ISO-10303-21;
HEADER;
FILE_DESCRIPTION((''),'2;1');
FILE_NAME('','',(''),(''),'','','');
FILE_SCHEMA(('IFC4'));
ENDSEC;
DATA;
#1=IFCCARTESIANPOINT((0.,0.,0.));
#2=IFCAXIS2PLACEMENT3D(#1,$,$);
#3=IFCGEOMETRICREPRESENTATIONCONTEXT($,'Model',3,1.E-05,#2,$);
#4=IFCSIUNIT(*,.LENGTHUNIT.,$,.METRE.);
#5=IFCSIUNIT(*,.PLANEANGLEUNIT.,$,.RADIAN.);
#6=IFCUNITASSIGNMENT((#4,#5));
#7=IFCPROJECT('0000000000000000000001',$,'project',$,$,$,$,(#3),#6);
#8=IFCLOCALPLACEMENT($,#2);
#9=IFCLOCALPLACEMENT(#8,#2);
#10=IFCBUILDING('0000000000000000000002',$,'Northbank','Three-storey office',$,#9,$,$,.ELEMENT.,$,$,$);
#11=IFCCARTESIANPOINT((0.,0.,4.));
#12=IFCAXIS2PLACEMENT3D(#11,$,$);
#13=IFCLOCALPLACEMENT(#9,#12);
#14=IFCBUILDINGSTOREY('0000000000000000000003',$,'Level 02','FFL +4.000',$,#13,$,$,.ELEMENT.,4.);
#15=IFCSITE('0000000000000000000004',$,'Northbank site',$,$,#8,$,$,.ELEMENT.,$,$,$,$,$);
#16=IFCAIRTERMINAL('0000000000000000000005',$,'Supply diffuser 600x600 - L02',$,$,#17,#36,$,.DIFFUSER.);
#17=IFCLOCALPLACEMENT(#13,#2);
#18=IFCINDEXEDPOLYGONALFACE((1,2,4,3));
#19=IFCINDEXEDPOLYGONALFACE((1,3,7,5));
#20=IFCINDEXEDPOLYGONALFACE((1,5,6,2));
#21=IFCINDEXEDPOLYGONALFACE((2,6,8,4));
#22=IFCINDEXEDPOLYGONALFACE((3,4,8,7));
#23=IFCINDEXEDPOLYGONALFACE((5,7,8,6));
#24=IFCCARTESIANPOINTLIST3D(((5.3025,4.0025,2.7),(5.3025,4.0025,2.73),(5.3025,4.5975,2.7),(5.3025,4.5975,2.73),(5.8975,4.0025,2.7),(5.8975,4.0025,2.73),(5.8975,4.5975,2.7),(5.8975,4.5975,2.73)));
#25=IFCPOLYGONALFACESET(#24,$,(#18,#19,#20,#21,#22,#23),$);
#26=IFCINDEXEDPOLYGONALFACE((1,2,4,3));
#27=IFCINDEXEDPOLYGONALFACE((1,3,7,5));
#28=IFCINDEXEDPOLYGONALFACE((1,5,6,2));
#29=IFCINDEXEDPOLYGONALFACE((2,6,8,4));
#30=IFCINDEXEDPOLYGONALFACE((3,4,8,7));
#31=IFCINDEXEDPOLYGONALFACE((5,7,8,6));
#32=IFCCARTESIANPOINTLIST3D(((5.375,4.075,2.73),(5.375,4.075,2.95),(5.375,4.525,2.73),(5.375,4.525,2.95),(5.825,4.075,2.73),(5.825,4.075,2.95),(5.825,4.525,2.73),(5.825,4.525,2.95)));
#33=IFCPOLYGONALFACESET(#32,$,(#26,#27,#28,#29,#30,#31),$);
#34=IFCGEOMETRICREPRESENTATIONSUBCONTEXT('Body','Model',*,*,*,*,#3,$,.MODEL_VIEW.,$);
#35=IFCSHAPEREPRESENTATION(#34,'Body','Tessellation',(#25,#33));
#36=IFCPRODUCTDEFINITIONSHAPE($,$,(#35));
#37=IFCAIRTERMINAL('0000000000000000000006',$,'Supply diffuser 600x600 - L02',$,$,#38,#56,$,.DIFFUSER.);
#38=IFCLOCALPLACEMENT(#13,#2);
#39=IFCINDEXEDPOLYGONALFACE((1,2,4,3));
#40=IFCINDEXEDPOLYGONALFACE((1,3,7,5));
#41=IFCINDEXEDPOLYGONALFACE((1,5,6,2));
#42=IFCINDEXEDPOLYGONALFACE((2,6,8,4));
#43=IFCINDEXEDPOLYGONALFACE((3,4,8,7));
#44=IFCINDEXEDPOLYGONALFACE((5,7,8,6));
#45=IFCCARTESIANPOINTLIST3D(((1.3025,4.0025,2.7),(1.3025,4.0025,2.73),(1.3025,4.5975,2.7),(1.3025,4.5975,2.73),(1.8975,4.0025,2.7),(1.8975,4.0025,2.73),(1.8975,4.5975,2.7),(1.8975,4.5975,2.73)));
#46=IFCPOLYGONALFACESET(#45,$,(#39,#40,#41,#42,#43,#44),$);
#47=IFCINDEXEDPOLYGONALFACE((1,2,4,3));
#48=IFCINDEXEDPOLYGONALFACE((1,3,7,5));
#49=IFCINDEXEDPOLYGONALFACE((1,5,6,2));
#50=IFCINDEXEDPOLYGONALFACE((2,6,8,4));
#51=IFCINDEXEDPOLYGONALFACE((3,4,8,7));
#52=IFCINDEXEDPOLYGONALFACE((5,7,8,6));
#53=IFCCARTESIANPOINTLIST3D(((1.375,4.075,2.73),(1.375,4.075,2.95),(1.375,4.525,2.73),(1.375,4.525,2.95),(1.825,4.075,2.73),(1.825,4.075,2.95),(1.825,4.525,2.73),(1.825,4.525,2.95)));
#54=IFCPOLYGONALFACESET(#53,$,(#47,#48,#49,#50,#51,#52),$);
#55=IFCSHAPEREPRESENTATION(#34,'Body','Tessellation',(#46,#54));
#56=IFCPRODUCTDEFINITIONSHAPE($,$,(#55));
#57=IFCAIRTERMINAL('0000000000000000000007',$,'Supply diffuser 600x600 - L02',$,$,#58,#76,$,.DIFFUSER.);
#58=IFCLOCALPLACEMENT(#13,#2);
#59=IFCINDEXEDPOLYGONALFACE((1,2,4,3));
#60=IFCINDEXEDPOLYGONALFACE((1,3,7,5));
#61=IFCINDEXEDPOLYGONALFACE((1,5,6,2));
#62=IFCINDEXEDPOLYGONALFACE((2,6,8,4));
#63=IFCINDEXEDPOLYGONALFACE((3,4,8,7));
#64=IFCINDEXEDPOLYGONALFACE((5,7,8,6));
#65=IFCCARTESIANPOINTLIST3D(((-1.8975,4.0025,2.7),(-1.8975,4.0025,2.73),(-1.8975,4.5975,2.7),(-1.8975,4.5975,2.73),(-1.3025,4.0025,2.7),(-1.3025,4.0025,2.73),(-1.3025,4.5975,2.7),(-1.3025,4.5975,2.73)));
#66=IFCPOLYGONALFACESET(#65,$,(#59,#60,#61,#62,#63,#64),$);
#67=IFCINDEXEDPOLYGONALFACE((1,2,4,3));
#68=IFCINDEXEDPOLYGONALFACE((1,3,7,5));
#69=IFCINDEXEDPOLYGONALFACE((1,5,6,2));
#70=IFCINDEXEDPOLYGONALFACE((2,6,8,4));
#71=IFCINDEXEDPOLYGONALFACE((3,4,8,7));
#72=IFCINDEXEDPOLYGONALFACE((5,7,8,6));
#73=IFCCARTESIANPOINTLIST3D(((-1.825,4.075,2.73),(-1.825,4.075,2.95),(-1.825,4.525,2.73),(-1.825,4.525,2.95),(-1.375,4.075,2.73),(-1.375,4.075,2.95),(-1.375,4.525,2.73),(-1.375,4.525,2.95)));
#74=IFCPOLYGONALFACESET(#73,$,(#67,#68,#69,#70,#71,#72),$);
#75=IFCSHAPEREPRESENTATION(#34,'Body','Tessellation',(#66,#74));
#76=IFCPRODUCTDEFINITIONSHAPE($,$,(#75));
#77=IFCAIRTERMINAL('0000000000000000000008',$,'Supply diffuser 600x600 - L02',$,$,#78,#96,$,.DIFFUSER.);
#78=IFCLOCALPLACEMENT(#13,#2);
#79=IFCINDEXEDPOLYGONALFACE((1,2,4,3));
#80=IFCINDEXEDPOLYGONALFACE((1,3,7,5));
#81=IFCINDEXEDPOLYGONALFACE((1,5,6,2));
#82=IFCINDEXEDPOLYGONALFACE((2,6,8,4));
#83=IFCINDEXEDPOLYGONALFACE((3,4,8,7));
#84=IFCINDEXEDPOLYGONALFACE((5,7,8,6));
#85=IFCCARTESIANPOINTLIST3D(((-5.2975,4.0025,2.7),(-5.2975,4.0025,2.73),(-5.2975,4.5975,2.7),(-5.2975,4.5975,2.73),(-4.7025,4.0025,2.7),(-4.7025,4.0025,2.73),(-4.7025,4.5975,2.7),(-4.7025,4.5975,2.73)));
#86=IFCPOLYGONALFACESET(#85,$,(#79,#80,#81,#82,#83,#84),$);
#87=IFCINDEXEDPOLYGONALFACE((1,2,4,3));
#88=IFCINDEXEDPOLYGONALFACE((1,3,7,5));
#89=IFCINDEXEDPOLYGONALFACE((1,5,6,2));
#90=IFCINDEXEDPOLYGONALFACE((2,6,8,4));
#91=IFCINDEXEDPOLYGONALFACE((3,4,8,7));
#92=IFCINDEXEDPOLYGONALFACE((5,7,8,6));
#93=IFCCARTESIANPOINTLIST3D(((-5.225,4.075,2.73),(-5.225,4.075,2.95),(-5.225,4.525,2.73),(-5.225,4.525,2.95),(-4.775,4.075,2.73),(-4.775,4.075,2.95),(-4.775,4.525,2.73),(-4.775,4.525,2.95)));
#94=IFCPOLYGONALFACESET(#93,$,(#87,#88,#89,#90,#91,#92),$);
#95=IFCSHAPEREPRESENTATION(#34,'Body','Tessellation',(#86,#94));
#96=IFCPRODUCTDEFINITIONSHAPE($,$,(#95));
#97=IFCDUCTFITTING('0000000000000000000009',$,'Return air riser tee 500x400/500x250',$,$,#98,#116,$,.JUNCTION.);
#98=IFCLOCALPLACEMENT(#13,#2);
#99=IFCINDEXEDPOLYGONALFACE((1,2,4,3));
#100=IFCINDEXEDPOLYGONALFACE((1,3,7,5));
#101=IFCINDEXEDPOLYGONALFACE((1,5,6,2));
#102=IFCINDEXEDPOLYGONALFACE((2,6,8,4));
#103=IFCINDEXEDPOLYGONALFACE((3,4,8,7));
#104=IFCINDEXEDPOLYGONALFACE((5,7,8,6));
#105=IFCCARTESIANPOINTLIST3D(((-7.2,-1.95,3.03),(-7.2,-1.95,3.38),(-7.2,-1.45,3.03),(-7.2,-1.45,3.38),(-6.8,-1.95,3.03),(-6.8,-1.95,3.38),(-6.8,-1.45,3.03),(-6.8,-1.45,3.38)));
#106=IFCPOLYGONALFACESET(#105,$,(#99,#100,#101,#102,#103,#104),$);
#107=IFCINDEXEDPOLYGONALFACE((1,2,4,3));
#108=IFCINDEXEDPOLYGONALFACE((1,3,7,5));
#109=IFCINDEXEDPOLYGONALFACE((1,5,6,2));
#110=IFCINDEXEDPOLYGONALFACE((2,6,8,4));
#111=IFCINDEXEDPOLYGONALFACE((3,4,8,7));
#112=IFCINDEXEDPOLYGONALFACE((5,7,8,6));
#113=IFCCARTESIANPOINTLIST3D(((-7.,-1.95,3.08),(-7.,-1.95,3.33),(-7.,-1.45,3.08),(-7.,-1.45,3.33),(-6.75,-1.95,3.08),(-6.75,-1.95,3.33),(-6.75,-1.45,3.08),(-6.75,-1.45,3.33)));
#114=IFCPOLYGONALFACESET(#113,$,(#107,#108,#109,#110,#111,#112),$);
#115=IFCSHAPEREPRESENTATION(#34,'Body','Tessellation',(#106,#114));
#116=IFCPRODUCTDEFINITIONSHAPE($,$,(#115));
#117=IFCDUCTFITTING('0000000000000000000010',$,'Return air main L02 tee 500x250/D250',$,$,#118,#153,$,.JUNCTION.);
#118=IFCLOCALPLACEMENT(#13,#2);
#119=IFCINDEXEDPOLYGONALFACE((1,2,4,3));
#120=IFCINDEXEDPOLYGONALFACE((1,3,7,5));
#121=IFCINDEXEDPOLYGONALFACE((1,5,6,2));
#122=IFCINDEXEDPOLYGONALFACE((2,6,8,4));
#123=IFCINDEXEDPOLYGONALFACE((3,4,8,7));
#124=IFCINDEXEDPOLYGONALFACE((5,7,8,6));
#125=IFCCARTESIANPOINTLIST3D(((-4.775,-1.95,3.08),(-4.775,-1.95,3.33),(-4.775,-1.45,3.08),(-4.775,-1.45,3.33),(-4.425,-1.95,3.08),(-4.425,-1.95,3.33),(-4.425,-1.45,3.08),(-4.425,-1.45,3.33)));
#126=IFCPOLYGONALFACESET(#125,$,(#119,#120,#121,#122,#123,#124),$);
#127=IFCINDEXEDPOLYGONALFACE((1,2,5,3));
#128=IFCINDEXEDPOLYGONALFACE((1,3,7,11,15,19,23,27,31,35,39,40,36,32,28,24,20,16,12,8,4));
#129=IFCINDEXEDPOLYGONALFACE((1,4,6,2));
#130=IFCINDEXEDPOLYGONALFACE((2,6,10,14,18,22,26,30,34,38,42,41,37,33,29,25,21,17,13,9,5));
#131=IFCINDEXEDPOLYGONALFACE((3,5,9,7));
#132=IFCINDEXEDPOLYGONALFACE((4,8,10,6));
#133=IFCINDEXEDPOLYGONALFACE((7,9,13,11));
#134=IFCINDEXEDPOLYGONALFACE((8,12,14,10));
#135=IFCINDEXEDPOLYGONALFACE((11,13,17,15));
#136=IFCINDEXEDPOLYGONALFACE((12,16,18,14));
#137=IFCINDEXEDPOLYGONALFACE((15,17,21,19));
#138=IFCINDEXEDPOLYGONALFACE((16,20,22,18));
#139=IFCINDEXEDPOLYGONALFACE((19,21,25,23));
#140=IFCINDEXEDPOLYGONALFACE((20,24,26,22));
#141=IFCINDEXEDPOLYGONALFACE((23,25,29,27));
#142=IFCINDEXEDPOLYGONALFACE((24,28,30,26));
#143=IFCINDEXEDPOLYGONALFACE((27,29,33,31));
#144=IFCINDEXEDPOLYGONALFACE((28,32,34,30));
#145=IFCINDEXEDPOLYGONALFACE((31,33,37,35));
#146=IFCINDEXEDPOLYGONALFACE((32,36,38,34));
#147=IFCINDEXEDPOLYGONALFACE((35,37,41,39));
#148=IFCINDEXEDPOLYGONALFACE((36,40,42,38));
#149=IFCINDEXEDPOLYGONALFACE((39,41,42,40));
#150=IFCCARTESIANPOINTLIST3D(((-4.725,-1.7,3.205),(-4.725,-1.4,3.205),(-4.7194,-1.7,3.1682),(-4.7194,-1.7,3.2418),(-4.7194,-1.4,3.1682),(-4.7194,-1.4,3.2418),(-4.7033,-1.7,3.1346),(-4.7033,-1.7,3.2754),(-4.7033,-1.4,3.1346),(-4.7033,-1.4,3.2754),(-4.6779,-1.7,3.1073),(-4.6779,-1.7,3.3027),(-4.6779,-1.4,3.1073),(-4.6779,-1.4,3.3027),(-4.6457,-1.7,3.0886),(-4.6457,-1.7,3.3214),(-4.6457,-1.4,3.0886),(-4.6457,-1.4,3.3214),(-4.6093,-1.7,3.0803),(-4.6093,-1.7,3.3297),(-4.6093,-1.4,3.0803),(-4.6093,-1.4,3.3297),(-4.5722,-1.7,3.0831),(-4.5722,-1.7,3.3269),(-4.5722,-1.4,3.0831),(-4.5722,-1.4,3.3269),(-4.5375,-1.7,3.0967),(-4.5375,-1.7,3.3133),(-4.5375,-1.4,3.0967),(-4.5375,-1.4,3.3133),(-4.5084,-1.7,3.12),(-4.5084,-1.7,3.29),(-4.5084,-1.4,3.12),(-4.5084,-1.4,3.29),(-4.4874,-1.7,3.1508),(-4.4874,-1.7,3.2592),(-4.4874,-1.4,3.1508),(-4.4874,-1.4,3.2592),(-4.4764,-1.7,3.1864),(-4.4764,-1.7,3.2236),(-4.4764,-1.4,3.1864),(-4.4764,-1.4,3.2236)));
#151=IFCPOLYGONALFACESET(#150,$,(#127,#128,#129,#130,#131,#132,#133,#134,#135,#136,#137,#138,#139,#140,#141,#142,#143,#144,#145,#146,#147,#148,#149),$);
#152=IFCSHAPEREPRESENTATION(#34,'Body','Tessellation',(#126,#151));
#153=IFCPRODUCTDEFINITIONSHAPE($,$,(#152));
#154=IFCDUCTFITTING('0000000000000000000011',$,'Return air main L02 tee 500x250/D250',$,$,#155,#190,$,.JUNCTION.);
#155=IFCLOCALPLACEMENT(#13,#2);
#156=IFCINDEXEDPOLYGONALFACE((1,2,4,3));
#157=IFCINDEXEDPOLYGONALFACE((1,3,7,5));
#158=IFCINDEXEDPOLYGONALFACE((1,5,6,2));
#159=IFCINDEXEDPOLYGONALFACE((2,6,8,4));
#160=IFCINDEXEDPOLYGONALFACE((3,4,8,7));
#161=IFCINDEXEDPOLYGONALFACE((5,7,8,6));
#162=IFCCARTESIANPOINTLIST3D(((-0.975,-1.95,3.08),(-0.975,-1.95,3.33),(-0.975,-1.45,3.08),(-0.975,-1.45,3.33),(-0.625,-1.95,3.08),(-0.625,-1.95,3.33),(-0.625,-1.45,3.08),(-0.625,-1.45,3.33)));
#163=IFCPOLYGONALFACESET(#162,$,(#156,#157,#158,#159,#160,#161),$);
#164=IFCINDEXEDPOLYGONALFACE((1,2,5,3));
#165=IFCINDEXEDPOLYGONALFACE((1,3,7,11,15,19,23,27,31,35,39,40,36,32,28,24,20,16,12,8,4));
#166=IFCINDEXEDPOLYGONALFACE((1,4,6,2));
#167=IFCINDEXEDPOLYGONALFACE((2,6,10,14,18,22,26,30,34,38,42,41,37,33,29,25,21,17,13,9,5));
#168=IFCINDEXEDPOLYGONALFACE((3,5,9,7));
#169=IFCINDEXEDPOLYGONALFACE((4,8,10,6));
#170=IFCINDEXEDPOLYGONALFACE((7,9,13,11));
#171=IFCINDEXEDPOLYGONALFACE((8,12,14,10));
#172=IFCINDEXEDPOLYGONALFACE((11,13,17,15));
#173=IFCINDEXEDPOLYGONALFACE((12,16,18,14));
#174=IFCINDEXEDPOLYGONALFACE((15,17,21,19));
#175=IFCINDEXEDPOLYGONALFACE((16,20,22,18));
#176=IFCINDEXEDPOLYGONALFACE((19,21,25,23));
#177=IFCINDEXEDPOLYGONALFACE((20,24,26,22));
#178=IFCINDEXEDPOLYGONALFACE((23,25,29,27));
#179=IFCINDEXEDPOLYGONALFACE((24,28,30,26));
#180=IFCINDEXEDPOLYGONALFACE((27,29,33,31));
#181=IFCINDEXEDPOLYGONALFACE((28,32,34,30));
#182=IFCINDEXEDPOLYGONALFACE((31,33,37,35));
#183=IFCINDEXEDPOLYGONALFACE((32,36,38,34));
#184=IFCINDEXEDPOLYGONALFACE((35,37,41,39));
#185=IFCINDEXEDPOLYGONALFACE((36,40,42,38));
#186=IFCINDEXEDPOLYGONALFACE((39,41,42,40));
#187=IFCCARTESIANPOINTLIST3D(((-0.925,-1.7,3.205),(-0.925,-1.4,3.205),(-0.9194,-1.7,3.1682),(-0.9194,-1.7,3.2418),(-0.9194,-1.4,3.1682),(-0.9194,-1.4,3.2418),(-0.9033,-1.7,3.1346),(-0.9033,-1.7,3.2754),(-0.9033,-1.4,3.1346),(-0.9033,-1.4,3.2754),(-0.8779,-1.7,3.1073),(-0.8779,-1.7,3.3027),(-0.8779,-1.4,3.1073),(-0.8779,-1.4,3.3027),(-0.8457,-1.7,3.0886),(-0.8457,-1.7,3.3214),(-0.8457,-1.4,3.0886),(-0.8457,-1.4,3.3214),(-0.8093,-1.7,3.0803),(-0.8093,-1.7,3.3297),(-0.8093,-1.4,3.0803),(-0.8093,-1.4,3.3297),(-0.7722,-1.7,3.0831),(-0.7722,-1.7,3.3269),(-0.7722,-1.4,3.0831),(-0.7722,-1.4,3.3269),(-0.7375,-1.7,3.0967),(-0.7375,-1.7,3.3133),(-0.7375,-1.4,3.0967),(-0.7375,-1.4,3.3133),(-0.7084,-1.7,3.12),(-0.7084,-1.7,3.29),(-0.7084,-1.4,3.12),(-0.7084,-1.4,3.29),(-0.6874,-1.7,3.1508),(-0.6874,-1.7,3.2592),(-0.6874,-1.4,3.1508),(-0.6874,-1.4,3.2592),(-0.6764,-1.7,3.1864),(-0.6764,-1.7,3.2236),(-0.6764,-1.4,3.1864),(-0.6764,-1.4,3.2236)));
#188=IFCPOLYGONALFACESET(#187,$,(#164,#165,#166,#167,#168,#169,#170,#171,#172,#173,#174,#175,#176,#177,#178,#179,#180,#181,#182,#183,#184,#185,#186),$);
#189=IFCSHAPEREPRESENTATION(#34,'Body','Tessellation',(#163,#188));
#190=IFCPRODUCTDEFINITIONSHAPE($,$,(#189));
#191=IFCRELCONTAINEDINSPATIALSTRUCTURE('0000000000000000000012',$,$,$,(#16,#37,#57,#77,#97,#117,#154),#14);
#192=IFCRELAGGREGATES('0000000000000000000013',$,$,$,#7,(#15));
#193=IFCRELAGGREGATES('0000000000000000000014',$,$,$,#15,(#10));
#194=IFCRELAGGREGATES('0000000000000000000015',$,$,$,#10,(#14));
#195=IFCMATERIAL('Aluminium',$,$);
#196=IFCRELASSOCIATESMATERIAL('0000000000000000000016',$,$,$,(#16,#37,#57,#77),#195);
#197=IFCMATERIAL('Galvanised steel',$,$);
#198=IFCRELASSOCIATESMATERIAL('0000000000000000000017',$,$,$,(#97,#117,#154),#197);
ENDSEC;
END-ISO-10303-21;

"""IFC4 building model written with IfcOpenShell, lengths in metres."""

from ifc_helpers import new_model, si_unit, frame, origin, place, context, subcontext, project, spatial, rectangle, circle, extrude, material, element, save


model = new_model("IFC4")

# Units and contexts
model_context = context("Model", 3, precision=1e-05, world=origin())
body_context = subcontext(model_context, "Body", "Model", "MODEL_VIEW")
ifc_project = project(units=[si_unit("LENGTHUNIT", "METRE"), si_unit("PLANEANGLEUNIT", "RADIAN")], contexts=[model_context])

# Site, building, storey
site_placement = place(None, origin())
site = spatial("IfcSite", under=ifc_project, at=site_placement, Name="Northbank site", CompositionType="ELEMENT")
building_placement = place(site_placement, origin())
building = spatial("IfcBuilding", under=site, at=building_placement, Name="Northbank", Description="Three-storey office", CompositionType="ELEMENT")
storey_placement = place(building_placement, frame((0.0, 0.0, 4.0)))
storey = spatial("IfcBuildingStorey", under=building, at=storey_placement, Name="Level 02", Description="FFL +4.000", CompositionType="ELEMENT", Elevation=4.0)

# Air terminal
ifc_material_1 = material(Name="Aluminium")
air_terminal_1_placement = place(storey_placement, frame((0.0, 0.0, -4.0)))
element("IfcAirTerminal", 1, at=air_terminal_1_placement, inside=storey, material=ifc_material_1, Name="Supply diffuser 600x600 - L02", PredefinedType="DIFFUSER", context=body_context, shape_type="SweptSolid", body=[
    extrude(rectangle(XDim=0.595, YDim=0.595), frame((5.6, 4.3, 6.7)), (0.0, 0.0, 1.0), 0.03),
    extrude(rectangle(XDim=0.45, YDim=0.45), frame((5.6, 4.3, 6.73)), (0.0, 0.0, 1.0), 0.22),
])

# Shared definitions
ifc_material_2 = material(Name="Galvanised steel")

# Air terminal
air_terminal_2_placement = place(storey_placement, frame((0.0, 0.0, -4.0)))
element("IfcAirTerminal", 2, at=air_terminal_2_placement, inside=storey, material=ifc_material_1, Name="Supply diffuser 600x600 - L02", PredefinedType="DIFFUSER", context=body_context, shape_type="SweptSolid", body=[
    extrude(rectangle(XDim=0.595, YDim=0.595), frame((1.6, 4.3, 6.7)), (0.0, 0.0, 1.0), 0.03),
    extrude(rectangle(XDim=0.45, YDim=0.45), frame((1.6, 4.3, 6.73)), (0.0, 0.0, 1.0), 0.22),
])

# Air terminal
air_terminal_3_placement = place(storey_placement, frame((0.0, 0.0, -4.0)))
element("IfcAirTerminal", 3, at=air_terminal_3_placement, inside=storey, material=ifc_material_1, Name="Supply diffuser 600x600 - L02", PredefinedType="DIFFUSER", context=body_context, shape_type="SweptSolid", body=[
    extrude(rectangle(XDim=0.595, YDim=0.595), frame((-1.6, 4.3, 6.7)), (0.0, 0.0, 1.0), 0.03),
    extrude(rectangle(XDim=0.45, YDim=0.45), frame((-1.6, 4.3, 6.73)), (0.0, 0.0, 1.0), 0.22),
])

# Air terminal
air_terminal_4_placement = place(storey_placement, frame((0.0, 0.0, -4.0)))
element("IfcAirTerminal", 4, at=air_terminal_4_placement, inside=storey, material=ifc_material_1, Name="Supply diffuser 600x600 - L02", PredefinedType="DIFFUSER", context=body_context, shape_type="SweptSolid", body=[
    extrude(rectangle(XDim=0.595, YDim=0.595), frame((-5.0, 4.3, 6.7)), (0.0, 0.0, 1.0), 0.03),
    extrude(rectangle(XDim=0.45, YDim=0.45), frame((-5.0, 4.3, 6.73)), (0.0, 0.0, 1.0), 0.22),
])

# Duct fitting
duct_fitting_1_placement = place(storey_placement, frame((0.0, 0.0, -4.0)))
element("IfcDuctFitting", 5, at=duct_fitting_1_placement, inside=storey, material=ifc_material_2, Name="Return air riser tee 500x400/500x250", PredefinedType="JUNCTION", context=body_context, shape_type="SweptSolid", body=[
    extrude(rectangle(XDim=0.5, YDim=0.4), frame((-7.0, -1.7, 7.38), z_axis=(0.0, 0.0, -1.0), x_axis=(0.0, -1.0, 0.0)), (0.0, 0.0, 1.0), 0.35),
    extrude(rectangle(XDim=0.5, YDim=0.25), frame((-7.0, -1.7, 7.205), z_axis=(1.0, 0.0, 0.0), x_axis=(0.0, 1.0, 0.0)), (0.0, 0.0, 1.0), 0.25),
])

# Duct fitting
duct_fitting_2_placement = place(storey_placement, frame((0.0, 0.0, -4.0)))
element("IfcDuctFitting", 6, at=duct_fitting_2_placement, inside=storey, material=ifc_material_2, Name="Return air main L02 tee 500x250/D250", PredefinedType="JUNCTION", context=body_context, shape_type="SweptSolid", body=[
    extrude(rectangle(XDim=0.5, YDim=0.25), frame((-4.775, -1.7, 7.205), z_axis=(1.0, 0.0, 0.0), x_axis=(0.0, 1.0, 0.0)), (0.0, 0.0, 1.0), 0.35),
    extrude(circle(Radius=0.125), frame((-4.6, -1.7, 7.205), z_axis=(0.0, 1.0, 0.0), x_axis=(-1.0, 0.0, 0.0)), (0.0, 0.0, 1.0), 0.3),
])

# Duct fitting
duct_fitting_3_placement = place(storey_placement, frame((0.0, 0.0, -4.0)))
element("IfcDuctFitting", 7, at=duct_fitting_3_placement, inside=storey, material=ifc_material_2, Name="Return air main L02 tee 500x250/D250", PredefinedType="JUNCTION", context=body_context, shape_type="SweptSolid", body=[
    extrude(rectangle(XDim=0.5, YDim=0.25), frame((-0.975, -1.7, 7.205), z_axis=(1.0, 0.0, 0.0), x_axis=(0.0, 1.0, 0.0)), (0.0, 0.0, 1.0), 0.35),
    extrude(circle(Radius=0.125), frame((-0.8, -1.7, 7.205), z_axis=(0.0, 1.0, 0.0), x_axis=(-1.0, 0.0, 0.0)), (0.0, 0.0, 1.0), 0.3),
])

save(model, "model.ifc")
